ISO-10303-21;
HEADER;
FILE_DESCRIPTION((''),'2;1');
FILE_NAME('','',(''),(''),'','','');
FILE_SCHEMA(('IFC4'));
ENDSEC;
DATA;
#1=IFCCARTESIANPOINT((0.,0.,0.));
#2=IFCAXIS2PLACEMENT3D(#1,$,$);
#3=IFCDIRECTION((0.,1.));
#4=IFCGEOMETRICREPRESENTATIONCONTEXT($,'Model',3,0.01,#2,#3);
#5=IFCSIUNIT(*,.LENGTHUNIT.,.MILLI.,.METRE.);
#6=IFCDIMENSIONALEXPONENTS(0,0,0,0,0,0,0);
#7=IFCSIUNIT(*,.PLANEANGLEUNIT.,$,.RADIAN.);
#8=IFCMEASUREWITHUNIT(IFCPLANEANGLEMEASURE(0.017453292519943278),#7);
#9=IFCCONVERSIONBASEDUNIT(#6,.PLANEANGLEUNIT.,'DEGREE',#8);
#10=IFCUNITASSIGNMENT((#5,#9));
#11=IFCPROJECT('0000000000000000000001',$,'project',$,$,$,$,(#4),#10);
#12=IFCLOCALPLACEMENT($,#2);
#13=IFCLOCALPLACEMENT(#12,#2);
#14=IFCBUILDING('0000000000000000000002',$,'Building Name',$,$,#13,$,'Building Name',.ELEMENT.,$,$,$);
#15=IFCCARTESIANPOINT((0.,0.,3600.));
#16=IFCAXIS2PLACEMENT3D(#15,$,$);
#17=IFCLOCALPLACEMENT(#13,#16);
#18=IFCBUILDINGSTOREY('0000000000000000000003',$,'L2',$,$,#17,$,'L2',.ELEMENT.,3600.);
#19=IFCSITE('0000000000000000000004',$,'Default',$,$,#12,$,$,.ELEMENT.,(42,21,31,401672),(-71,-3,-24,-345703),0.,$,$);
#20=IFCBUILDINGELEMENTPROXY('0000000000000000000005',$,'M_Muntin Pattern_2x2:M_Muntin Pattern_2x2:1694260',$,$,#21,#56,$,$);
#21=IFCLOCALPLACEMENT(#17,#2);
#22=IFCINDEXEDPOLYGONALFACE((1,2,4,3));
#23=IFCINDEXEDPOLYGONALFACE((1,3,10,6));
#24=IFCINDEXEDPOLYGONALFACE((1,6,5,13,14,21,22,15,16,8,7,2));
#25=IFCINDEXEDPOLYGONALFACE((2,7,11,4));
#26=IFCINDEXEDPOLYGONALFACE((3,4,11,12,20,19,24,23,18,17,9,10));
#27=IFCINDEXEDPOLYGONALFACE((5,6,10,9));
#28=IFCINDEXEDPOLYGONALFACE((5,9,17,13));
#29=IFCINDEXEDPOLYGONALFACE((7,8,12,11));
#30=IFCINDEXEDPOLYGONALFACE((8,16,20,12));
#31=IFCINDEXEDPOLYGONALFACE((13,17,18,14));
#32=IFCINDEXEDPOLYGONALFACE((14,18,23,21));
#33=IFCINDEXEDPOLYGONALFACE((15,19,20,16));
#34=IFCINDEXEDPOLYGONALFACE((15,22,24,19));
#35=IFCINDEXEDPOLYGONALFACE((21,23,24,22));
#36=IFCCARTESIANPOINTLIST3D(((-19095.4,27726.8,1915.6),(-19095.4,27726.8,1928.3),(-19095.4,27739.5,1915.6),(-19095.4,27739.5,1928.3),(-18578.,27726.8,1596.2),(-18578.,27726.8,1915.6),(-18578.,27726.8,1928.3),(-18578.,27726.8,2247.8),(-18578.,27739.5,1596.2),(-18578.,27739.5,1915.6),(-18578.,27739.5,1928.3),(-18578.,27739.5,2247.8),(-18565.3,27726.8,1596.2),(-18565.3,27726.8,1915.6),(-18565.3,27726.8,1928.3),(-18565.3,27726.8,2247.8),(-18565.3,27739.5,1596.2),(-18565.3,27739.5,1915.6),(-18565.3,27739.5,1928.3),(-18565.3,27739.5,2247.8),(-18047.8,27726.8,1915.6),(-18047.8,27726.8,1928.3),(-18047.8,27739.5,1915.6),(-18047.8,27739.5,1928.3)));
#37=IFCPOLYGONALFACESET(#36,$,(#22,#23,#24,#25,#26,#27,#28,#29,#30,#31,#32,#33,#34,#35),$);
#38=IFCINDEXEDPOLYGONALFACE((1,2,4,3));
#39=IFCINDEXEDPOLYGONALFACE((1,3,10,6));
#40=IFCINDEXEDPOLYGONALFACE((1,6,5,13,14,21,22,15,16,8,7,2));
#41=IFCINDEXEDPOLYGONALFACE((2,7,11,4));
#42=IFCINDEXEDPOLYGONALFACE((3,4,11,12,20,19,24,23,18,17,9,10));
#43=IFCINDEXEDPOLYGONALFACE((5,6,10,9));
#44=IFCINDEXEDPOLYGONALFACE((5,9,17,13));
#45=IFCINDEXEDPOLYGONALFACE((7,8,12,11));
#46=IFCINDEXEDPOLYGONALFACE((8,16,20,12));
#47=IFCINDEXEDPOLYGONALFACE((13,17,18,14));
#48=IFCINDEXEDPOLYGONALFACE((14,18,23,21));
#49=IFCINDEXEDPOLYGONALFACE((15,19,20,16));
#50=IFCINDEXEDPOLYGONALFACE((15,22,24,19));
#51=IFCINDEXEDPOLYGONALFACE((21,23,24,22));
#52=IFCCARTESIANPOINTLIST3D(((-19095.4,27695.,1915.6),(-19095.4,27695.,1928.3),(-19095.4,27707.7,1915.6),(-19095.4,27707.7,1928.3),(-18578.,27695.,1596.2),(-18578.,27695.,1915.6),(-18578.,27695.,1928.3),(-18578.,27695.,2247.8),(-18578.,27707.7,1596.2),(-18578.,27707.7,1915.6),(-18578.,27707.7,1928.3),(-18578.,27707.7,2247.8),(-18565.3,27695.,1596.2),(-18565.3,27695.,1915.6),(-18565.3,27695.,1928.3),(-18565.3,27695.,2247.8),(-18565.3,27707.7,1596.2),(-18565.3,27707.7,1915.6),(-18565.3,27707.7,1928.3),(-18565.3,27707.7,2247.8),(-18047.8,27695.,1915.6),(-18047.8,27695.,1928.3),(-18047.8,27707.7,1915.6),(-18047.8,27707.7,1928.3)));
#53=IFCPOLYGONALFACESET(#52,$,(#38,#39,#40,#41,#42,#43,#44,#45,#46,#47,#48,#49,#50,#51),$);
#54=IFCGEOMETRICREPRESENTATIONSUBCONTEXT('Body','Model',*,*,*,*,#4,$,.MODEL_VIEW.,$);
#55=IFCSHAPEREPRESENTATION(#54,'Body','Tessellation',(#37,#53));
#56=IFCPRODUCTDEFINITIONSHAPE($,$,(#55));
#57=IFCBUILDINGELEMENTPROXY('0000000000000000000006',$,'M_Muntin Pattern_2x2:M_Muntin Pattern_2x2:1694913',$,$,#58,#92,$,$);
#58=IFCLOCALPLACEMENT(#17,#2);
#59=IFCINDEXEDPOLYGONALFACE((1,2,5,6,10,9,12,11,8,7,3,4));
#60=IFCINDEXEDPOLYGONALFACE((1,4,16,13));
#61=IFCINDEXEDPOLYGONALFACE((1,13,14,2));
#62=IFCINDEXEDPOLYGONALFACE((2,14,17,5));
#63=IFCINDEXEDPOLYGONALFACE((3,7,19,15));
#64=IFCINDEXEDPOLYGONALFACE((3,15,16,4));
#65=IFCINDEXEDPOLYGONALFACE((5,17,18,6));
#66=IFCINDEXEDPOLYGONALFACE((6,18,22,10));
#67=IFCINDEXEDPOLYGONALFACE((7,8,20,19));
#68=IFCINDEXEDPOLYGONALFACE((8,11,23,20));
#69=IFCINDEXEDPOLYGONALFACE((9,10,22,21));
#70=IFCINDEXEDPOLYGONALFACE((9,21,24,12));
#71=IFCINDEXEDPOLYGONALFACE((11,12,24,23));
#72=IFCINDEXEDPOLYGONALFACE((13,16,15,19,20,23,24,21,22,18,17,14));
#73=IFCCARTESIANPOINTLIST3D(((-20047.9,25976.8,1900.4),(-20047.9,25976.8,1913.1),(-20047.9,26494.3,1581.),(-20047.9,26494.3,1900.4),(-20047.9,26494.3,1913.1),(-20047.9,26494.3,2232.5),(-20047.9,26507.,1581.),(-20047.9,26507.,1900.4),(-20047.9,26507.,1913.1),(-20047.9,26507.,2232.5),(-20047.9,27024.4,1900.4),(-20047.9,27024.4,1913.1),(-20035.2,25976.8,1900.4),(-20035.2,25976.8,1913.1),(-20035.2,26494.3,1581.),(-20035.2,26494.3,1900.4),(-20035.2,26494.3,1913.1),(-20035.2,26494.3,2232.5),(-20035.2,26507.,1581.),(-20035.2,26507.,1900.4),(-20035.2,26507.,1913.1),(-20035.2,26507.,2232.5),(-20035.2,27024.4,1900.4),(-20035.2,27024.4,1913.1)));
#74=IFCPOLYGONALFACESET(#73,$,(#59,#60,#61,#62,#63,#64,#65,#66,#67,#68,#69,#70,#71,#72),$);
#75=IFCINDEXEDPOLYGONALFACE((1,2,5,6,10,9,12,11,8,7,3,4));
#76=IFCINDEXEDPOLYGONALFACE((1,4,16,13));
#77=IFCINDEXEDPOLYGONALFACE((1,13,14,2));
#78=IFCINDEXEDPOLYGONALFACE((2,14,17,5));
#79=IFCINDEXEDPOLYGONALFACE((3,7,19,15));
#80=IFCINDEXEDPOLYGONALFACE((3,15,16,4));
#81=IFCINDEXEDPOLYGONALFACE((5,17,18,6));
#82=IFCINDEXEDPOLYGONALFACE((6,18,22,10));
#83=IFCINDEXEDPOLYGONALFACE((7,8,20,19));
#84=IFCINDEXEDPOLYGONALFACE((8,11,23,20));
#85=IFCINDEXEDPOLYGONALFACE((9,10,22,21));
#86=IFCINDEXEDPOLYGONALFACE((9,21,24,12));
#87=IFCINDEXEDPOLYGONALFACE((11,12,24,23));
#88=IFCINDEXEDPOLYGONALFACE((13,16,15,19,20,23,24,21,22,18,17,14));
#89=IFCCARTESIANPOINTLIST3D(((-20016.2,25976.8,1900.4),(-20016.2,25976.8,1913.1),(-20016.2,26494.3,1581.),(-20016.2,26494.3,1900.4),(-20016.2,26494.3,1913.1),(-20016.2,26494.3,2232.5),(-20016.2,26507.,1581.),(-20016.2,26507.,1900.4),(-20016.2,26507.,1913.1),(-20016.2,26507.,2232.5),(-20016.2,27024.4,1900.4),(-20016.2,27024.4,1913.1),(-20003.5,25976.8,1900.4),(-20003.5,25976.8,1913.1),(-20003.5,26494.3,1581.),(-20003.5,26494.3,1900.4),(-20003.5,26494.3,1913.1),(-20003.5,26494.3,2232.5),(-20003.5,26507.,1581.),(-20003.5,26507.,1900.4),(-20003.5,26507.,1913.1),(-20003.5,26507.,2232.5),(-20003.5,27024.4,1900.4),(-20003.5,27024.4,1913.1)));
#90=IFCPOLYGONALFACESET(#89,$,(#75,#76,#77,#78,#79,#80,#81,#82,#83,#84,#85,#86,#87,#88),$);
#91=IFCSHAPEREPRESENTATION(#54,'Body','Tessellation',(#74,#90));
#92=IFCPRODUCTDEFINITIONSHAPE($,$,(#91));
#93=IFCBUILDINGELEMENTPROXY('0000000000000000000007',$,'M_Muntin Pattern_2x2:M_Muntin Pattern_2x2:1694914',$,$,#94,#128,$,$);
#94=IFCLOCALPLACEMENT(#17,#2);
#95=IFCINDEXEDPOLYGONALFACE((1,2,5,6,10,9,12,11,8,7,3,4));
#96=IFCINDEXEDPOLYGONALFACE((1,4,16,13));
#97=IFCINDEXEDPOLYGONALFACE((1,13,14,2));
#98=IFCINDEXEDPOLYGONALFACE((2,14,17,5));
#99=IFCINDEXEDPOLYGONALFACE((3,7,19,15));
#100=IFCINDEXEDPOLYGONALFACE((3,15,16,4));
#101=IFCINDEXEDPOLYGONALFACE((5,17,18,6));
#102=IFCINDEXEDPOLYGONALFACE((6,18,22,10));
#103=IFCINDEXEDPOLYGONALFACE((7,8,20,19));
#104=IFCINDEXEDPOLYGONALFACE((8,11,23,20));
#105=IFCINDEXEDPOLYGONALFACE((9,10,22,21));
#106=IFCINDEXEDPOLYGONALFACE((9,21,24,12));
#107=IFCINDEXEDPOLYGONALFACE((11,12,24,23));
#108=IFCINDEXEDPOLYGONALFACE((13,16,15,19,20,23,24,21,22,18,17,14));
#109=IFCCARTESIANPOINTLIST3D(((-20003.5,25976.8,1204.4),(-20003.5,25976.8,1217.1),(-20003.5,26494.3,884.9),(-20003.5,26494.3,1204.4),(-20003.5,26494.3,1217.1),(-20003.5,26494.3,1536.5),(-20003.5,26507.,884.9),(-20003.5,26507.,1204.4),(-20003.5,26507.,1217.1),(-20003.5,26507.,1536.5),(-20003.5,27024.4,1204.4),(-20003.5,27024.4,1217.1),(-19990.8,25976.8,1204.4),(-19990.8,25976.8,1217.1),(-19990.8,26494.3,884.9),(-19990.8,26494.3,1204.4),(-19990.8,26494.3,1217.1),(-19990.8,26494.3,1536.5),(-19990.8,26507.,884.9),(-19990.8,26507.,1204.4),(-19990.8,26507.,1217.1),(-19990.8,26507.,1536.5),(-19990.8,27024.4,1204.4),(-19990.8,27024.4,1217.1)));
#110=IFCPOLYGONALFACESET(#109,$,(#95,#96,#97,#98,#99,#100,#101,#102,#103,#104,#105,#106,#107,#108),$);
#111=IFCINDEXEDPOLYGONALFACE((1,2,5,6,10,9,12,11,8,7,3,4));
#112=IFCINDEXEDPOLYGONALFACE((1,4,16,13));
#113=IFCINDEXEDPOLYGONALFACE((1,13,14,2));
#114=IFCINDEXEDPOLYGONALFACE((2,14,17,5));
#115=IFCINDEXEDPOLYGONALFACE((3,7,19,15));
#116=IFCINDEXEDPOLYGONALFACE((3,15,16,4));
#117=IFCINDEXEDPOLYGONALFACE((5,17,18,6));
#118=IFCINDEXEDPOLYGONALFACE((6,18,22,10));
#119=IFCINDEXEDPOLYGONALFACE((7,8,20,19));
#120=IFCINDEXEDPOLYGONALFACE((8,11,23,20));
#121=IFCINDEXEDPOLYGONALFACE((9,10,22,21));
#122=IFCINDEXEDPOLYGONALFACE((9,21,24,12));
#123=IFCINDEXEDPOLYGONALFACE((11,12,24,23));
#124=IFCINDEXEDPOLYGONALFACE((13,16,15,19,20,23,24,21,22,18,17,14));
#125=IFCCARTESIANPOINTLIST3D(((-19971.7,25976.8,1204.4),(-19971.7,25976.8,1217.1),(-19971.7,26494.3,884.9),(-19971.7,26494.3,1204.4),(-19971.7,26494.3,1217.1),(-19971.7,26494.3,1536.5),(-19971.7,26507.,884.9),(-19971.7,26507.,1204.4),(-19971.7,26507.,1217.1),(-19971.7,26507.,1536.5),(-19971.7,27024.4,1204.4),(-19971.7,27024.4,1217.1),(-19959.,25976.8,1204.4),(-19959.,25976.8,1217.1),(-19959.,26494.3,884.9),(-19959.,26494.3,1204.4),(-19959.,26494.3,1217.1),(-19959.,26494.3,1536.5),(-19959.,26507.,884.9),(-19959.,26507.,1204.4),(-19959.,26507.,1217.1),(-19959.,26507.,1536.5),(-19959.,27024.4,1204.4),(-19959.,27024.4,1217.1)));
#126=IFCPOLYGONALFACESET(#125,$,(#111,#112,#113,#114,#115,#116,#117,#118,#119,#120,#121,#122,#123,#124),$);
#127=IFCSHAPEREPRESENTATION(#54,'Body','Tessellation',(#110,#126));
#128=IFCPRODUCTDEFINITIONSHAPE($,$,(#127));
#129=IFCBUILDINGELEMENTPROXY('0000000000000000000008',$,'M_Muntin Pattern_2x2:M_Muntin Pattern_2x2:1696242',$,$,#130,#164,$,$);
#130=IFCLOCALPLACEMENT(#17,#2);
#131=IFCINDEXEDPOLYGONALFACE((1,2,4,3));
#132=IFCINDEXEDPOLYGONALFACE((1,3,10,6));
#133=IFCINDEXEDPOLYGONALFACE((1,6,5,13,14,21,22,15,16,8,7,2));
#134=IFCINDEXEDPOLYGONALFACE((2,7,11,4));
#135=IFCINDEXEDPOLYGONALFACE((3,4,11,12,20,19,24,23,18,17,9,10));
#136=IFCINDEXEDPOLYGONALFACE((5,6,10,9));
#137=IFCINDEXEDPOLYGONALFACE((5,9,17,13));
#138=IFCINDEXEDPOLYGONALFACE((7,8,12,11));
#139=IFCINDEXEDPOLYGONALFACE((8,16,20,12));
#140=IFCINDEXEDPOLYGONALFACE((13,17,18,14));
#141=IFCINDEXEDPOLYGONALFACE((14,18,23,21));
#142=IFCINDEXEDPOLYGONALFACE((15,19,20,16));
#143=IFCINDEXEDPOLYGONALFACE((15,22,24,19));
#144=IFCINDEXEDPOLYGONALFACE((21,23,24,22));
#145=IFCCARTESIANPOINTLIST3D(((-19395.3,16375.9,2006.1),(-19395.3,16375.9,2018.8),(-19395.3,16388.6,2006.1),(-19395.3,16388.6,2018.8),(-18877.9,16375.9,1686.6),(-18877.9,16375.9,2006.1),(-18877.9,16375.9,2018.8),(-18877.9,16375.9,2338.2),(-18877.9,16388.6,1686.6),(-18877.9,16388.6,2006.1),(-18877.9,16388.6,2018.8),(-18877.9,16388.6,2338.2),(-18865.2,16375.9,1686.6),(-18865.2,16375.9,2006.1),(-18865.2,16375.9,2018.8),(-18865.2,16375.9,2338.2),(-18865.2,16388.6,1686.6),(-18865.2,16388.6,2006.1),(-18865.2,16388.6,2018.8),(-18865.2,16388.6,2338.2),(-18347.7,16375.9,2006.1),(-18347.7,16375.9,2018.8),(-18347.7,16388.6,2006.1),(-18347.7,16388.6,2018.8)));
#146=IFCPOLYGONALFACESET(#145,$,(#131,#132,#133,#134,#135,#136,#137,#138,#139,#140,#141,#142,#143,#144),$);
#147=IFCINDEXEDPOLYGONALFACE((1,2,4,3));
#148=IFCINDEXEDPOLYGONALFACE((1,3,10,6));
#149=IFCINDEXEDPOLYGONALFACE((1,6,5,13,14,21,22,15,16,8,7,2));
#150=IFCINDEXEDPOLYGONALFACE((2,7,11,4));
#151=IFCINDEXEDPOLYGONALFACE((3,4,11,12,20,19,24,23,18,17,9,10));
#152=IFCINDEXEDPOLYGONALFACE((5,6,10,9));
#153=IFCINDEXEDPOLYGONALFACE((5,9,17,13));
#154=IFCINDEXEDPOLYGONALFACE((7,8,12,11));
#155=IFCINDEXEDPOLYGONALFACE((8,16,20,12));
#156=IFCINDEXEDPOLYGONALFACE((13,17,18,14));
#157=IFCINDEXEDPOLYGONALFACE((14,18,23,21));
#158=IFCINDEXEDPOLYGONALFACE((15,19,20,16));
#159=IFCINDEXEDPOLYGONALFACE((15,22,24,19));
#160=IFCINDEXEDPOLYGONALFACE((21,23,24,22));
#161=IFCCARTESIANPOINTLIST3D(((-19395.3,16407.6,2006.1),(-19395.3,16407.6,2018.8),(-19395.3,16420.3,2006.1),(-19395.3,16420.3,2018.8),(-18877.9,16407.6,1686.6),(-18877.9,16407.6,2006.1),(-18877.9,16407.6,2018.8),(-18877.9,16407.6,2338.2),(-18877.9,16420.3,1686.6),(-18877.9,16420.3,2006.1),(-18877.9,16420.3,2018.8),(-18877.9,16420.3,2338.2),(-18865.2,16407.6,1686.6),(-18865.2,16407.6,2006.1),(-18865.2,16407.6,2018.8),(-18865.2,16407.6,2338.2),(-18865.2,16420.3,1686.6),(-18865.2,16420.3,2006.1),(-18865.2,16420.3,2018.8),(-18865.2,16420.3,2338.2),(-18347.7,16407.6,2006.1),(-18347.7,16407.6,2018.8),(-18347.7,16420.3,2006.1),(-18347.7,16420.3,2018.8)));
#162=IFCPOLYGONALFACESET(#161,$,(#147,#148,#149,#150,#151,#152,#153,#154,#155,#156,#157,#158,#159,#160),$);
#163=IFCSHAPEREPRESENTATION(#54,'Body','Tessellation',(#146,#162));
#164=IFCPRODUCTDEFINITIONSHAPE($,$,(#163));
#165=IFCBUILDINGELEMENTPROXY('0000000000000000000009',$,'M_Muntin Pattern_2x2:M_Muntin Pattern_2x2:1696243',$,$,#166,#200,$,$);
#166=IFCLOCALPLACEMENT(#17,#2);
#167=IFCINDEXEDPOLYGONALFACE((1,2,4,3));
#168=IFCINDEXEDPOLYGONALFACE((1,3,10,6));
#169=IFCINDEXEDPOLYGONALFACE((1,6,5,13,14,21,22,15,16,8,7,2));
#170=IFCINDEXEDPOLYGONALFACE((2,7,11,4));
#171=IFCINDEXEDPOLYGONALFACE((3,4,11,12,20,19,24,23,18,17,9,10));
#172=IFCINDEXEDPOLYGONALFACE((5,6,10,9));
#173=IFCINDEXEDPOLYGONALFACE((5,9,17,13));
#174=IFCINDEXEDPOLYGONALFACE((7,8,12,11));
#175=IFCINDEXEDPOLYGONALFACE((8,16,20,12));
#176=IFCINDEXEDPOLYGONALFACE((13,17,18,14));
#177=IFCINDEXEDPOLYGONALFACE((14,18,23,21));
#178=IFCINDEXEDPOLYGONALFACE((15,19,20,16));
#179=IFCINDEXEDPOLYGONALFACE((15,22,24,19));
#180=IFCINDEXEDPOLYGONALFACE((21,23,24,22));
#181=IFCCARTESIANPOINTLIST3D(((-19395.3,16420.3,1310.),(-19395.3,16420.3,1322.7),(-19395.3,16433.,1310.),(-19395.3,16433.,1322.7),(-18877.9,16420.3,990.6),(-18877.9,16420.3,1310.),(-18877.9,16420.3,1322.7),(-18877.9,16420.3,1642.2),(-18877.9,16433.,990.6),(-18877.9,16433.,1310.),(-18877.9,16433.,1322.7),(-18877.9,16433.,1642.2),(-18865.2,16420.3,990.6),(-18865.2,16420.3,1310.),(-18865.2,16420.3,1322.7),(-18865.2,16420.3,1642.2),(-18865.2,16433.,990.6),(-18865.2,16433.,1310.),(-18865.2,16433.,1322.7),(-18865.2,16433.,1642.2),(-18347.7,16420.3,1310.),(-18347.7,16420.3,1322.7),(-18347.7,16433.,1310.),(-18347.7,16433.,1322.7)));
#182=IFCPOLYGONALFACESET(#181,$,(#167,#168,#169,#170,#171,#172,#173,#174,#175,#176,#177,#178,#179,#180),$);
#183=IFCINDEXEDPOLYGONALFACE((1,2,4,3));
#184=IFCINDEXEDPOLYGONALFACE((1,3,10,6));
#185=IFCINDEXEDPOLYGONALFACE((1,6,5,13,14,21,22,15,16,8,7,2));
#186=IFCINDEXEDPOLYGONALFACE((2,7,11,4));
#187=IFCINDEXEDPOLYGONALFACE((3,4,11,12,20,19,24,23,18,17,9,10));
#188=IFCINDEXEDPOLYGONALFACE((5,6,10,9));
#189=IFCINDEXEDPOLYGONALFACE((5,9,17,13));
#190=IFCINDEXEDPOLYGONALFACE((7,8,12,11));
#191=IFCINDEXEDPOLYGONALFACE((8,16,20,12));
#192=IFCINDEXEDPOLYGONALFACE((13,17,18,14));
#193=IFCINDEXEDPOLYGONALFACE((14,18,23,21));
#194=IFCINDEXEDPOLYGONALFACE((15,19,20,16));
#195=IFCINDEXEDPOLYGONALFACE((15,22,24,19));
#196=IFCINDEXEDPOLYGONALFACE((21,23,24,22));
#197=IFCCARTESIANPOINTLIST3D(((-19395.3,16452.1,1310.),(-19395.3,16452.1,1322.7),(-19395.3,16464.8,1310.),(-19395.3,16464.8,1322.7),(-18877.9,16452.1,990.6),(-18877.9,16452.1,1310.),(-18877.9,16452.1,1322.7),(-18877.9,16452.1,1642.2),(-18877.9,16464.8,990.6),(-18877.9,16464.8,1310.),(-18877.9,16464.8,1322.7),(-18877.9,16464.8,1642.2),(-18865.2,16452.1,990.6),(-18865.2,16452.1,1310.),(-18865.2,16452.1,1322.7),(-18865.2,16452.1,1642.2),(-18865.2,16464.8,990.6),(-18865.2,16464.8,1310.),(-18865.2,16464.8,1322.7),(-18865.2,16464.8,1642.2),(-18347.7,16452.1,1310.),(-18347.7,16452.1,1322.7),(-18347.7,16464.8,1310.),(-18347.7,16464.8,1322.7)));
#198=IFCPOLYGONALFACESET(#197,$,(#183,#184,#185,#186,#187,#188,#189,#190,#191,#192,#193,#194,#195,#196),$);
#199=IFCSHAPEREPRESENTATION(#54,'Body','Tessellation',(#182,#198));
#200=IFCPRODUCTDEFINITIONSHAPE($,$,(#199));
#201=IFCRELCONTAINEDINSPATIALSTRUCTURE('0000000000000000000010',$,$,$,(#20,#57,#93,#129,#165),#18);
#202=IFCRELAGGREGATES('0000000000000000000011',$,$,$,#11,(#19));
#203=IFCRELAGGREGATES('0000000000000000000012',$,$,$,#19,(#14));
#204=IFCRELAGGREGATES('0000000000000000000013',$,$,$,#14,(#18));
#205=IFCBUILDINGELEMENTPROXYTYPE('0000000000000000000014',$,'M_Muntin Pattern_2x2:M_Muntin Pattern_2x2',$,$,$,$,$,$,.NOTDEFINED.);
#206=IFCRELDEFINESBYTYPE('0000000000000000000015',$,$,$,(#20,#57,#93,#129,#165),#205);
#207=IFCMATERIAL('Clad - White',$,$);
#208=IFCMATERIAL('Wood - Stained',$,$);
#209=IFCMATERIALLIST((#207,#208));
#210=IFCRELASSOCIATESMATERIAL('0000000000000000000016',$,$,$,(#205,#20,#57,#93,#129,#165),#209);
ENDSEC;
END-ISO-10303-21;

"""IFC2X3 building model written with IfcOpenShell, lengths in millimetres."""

from ifc_helpers import new_model, entity, si_unit, converted_unit, direction, frame, origin, place, context, subcontext, project, spatial, polyline, outline, extrude, source, transform, mapped, material, material_list, type_object, type_shapes, element, save


model = new_model("IFC2X3")

# Units and contexts
model_context = context("Model", 3, precision=0.01, world=origin(), true_north=direction((0.0, 1.0)))
body_context = subcontext(model_context, "Body", "Model", "MODEL_VIEW")
ifc_project = project(units=[si_unit("LENGTHUNIT", "METRE", prefix="MILLI"), converted_unit("PLANEANGLEUNIT", "DEGREE", entity("IfcPlaneAngleMeasure", 0.017453292519943278), si_unit("PLANEANGLEUNIT", "RADIAN"), dimensions=[0, 0, 0, 0, 0, 0, 0])], contexts=[model_context])

# Site, building, storey
site_placement = place(None, origin())
site = spatial("IfcSite", under=ifc_project, at=site_placement, Name="Default", CompositionType="ELEMENT", RefLatitude=(42, 21, 31, 401672), RefLongitude=(-71, -3, -24, -345703), RefElevation=0.0)
building_placement = place(site_placement, origin())
building = spatial("IfcBuilding", under=site, at=building_placement, Name="Building Name", LongName="Building Name", CompositionType="ELEMENT")
storey_placement = place(building_placement, frame((0.0, 0.0, 3600.0)))
storey = spatial("IfcBuildingStorey", under=building, at=storey_placement, Name="L2", LongName="L2", CompositionType="ELEMENT", Elevation=3600.0)

# Shared definitions
ifc_material_1 = material(Name="Wood - Stained")

# Building element proxies
ifc_material_2 = material(Name="Clad - White")
ifc_material_list_1 = material_list([ifc_material_2, ifc_material_1])
building_element_proxy_type_1 = type_object("IfcBuildingElementProxyType", Name="M_Muntin Pattern_2x2:M_Muntin Pattern_2x2", PredefinedType="NOTDEFINED", material=ifc_material_list_1)
shared_shape_1 = source(origin(), body_context, "Body", "SweptSolid", [
    extrude(outline(polyline([(6.4, -6.4), (325.8, -6.4), (325.8, 6.3), (6.4, 6.3), (6.4, 523.8), (-6.3, 523.8), (-6.3, 6.3), (-325.8, 6.3), (-325.8, -6.4), (-6.3, -6.4), (-6.3, -523.8), (6.4, -523.8), (6.4, -6.4)])), frame((0.0, 9.5, 325.8), z_axis=(0.0, 1.0, 0.0), x_axis=(0.0, 0.0, 1.0)), (0.0, 0.0, 1.0), 12.7),
    extrude(outline(polyline([(6.4, -6.4), (325.8, -6.4), (325.8, 6.3), (6.4, 6.3), (6.4, 523.8), (-6.3, 523.8), (-6.3, 6.3), (-325.8, 6.3), (-325.8, -6.4), (-6.3, -6.4), (-6.3, -523.8), (6.4, -523.8), (6.4, -6.4)])), frame((0.0, -22.2, 325.8), z_axis=(0.0, 1.0, 0.0), x_axis=(0.0, 0.0, 1.0)), (0.0, 0.0, 1.0), 12.7),
])
type_shapes(building_element_proxy_type_1, [shared_shape_1])
proxy_1_placement = place(storey_placement, frame((-18571.6, 27717.2, 1596.2)))
element("IfcBuildingElementProxy", 1, at=proxy_1_placement, inside=storey, type_object=building_element_proxy_type_1, material=ifc_material_list_1, Name="M_Muntin Pattern_2x2:M_Muntin Pattern_2x2:1694260", context=body_context, shape_type="MappedRepresentation", body=[
    mapped(shared_shape_1, transform((0.0, 0.0, 0.0), scale=1.0)),
])
for number, where, z_axis, x_axis, name in (
    (2, (-20025.7, 26500.6, 1581.0), (0.0, 0.0, 1.0), (0.0, 1.0, 0.0), "M_Muntin Pattern_2x2:M_Muntin Pattern_2x2:1694913"),
    (3, (-19981.3, 26500.6, 884.9), (0.0, 0.0, 1.0), (0.0, 1.0, 0.0), "M_Muntin Pattern_2x2:M_Muntin Pattern_2x2:1694914"),
    (4, (-18871.5, 16398.1, 1686.6), (0.0, 0.0, 1.0), (-1.0, 0.0, 0.0), "M_Muntin Pattern_2x2:M_Muntin Pattern_2x2:1696242"),
    (5, (-18871.5, 16442.5, 990.6), (0.0, 0.0, 1.0), (-1.0, 0.0, 0.0), "M_Muntin Pattern_2x2:M_Muntin Pattern_2x2:1696243"),
):
    element("IfcBuildingElementProxy", number, at=place(storey_placement, frame(where, z_axis=z_axis, x_axis=x_axis)), inside=storey, type_object=building_element_proxy_type_1, material=ifc_material_list_1, Name=name, context=body_context, shape_type="MappedRepresentation", body=[
        mapped(shared_shape_1, transform((0.0, 0.0, 0.0), scale=1.0)),
    ])

save(model, "model.ifc")
